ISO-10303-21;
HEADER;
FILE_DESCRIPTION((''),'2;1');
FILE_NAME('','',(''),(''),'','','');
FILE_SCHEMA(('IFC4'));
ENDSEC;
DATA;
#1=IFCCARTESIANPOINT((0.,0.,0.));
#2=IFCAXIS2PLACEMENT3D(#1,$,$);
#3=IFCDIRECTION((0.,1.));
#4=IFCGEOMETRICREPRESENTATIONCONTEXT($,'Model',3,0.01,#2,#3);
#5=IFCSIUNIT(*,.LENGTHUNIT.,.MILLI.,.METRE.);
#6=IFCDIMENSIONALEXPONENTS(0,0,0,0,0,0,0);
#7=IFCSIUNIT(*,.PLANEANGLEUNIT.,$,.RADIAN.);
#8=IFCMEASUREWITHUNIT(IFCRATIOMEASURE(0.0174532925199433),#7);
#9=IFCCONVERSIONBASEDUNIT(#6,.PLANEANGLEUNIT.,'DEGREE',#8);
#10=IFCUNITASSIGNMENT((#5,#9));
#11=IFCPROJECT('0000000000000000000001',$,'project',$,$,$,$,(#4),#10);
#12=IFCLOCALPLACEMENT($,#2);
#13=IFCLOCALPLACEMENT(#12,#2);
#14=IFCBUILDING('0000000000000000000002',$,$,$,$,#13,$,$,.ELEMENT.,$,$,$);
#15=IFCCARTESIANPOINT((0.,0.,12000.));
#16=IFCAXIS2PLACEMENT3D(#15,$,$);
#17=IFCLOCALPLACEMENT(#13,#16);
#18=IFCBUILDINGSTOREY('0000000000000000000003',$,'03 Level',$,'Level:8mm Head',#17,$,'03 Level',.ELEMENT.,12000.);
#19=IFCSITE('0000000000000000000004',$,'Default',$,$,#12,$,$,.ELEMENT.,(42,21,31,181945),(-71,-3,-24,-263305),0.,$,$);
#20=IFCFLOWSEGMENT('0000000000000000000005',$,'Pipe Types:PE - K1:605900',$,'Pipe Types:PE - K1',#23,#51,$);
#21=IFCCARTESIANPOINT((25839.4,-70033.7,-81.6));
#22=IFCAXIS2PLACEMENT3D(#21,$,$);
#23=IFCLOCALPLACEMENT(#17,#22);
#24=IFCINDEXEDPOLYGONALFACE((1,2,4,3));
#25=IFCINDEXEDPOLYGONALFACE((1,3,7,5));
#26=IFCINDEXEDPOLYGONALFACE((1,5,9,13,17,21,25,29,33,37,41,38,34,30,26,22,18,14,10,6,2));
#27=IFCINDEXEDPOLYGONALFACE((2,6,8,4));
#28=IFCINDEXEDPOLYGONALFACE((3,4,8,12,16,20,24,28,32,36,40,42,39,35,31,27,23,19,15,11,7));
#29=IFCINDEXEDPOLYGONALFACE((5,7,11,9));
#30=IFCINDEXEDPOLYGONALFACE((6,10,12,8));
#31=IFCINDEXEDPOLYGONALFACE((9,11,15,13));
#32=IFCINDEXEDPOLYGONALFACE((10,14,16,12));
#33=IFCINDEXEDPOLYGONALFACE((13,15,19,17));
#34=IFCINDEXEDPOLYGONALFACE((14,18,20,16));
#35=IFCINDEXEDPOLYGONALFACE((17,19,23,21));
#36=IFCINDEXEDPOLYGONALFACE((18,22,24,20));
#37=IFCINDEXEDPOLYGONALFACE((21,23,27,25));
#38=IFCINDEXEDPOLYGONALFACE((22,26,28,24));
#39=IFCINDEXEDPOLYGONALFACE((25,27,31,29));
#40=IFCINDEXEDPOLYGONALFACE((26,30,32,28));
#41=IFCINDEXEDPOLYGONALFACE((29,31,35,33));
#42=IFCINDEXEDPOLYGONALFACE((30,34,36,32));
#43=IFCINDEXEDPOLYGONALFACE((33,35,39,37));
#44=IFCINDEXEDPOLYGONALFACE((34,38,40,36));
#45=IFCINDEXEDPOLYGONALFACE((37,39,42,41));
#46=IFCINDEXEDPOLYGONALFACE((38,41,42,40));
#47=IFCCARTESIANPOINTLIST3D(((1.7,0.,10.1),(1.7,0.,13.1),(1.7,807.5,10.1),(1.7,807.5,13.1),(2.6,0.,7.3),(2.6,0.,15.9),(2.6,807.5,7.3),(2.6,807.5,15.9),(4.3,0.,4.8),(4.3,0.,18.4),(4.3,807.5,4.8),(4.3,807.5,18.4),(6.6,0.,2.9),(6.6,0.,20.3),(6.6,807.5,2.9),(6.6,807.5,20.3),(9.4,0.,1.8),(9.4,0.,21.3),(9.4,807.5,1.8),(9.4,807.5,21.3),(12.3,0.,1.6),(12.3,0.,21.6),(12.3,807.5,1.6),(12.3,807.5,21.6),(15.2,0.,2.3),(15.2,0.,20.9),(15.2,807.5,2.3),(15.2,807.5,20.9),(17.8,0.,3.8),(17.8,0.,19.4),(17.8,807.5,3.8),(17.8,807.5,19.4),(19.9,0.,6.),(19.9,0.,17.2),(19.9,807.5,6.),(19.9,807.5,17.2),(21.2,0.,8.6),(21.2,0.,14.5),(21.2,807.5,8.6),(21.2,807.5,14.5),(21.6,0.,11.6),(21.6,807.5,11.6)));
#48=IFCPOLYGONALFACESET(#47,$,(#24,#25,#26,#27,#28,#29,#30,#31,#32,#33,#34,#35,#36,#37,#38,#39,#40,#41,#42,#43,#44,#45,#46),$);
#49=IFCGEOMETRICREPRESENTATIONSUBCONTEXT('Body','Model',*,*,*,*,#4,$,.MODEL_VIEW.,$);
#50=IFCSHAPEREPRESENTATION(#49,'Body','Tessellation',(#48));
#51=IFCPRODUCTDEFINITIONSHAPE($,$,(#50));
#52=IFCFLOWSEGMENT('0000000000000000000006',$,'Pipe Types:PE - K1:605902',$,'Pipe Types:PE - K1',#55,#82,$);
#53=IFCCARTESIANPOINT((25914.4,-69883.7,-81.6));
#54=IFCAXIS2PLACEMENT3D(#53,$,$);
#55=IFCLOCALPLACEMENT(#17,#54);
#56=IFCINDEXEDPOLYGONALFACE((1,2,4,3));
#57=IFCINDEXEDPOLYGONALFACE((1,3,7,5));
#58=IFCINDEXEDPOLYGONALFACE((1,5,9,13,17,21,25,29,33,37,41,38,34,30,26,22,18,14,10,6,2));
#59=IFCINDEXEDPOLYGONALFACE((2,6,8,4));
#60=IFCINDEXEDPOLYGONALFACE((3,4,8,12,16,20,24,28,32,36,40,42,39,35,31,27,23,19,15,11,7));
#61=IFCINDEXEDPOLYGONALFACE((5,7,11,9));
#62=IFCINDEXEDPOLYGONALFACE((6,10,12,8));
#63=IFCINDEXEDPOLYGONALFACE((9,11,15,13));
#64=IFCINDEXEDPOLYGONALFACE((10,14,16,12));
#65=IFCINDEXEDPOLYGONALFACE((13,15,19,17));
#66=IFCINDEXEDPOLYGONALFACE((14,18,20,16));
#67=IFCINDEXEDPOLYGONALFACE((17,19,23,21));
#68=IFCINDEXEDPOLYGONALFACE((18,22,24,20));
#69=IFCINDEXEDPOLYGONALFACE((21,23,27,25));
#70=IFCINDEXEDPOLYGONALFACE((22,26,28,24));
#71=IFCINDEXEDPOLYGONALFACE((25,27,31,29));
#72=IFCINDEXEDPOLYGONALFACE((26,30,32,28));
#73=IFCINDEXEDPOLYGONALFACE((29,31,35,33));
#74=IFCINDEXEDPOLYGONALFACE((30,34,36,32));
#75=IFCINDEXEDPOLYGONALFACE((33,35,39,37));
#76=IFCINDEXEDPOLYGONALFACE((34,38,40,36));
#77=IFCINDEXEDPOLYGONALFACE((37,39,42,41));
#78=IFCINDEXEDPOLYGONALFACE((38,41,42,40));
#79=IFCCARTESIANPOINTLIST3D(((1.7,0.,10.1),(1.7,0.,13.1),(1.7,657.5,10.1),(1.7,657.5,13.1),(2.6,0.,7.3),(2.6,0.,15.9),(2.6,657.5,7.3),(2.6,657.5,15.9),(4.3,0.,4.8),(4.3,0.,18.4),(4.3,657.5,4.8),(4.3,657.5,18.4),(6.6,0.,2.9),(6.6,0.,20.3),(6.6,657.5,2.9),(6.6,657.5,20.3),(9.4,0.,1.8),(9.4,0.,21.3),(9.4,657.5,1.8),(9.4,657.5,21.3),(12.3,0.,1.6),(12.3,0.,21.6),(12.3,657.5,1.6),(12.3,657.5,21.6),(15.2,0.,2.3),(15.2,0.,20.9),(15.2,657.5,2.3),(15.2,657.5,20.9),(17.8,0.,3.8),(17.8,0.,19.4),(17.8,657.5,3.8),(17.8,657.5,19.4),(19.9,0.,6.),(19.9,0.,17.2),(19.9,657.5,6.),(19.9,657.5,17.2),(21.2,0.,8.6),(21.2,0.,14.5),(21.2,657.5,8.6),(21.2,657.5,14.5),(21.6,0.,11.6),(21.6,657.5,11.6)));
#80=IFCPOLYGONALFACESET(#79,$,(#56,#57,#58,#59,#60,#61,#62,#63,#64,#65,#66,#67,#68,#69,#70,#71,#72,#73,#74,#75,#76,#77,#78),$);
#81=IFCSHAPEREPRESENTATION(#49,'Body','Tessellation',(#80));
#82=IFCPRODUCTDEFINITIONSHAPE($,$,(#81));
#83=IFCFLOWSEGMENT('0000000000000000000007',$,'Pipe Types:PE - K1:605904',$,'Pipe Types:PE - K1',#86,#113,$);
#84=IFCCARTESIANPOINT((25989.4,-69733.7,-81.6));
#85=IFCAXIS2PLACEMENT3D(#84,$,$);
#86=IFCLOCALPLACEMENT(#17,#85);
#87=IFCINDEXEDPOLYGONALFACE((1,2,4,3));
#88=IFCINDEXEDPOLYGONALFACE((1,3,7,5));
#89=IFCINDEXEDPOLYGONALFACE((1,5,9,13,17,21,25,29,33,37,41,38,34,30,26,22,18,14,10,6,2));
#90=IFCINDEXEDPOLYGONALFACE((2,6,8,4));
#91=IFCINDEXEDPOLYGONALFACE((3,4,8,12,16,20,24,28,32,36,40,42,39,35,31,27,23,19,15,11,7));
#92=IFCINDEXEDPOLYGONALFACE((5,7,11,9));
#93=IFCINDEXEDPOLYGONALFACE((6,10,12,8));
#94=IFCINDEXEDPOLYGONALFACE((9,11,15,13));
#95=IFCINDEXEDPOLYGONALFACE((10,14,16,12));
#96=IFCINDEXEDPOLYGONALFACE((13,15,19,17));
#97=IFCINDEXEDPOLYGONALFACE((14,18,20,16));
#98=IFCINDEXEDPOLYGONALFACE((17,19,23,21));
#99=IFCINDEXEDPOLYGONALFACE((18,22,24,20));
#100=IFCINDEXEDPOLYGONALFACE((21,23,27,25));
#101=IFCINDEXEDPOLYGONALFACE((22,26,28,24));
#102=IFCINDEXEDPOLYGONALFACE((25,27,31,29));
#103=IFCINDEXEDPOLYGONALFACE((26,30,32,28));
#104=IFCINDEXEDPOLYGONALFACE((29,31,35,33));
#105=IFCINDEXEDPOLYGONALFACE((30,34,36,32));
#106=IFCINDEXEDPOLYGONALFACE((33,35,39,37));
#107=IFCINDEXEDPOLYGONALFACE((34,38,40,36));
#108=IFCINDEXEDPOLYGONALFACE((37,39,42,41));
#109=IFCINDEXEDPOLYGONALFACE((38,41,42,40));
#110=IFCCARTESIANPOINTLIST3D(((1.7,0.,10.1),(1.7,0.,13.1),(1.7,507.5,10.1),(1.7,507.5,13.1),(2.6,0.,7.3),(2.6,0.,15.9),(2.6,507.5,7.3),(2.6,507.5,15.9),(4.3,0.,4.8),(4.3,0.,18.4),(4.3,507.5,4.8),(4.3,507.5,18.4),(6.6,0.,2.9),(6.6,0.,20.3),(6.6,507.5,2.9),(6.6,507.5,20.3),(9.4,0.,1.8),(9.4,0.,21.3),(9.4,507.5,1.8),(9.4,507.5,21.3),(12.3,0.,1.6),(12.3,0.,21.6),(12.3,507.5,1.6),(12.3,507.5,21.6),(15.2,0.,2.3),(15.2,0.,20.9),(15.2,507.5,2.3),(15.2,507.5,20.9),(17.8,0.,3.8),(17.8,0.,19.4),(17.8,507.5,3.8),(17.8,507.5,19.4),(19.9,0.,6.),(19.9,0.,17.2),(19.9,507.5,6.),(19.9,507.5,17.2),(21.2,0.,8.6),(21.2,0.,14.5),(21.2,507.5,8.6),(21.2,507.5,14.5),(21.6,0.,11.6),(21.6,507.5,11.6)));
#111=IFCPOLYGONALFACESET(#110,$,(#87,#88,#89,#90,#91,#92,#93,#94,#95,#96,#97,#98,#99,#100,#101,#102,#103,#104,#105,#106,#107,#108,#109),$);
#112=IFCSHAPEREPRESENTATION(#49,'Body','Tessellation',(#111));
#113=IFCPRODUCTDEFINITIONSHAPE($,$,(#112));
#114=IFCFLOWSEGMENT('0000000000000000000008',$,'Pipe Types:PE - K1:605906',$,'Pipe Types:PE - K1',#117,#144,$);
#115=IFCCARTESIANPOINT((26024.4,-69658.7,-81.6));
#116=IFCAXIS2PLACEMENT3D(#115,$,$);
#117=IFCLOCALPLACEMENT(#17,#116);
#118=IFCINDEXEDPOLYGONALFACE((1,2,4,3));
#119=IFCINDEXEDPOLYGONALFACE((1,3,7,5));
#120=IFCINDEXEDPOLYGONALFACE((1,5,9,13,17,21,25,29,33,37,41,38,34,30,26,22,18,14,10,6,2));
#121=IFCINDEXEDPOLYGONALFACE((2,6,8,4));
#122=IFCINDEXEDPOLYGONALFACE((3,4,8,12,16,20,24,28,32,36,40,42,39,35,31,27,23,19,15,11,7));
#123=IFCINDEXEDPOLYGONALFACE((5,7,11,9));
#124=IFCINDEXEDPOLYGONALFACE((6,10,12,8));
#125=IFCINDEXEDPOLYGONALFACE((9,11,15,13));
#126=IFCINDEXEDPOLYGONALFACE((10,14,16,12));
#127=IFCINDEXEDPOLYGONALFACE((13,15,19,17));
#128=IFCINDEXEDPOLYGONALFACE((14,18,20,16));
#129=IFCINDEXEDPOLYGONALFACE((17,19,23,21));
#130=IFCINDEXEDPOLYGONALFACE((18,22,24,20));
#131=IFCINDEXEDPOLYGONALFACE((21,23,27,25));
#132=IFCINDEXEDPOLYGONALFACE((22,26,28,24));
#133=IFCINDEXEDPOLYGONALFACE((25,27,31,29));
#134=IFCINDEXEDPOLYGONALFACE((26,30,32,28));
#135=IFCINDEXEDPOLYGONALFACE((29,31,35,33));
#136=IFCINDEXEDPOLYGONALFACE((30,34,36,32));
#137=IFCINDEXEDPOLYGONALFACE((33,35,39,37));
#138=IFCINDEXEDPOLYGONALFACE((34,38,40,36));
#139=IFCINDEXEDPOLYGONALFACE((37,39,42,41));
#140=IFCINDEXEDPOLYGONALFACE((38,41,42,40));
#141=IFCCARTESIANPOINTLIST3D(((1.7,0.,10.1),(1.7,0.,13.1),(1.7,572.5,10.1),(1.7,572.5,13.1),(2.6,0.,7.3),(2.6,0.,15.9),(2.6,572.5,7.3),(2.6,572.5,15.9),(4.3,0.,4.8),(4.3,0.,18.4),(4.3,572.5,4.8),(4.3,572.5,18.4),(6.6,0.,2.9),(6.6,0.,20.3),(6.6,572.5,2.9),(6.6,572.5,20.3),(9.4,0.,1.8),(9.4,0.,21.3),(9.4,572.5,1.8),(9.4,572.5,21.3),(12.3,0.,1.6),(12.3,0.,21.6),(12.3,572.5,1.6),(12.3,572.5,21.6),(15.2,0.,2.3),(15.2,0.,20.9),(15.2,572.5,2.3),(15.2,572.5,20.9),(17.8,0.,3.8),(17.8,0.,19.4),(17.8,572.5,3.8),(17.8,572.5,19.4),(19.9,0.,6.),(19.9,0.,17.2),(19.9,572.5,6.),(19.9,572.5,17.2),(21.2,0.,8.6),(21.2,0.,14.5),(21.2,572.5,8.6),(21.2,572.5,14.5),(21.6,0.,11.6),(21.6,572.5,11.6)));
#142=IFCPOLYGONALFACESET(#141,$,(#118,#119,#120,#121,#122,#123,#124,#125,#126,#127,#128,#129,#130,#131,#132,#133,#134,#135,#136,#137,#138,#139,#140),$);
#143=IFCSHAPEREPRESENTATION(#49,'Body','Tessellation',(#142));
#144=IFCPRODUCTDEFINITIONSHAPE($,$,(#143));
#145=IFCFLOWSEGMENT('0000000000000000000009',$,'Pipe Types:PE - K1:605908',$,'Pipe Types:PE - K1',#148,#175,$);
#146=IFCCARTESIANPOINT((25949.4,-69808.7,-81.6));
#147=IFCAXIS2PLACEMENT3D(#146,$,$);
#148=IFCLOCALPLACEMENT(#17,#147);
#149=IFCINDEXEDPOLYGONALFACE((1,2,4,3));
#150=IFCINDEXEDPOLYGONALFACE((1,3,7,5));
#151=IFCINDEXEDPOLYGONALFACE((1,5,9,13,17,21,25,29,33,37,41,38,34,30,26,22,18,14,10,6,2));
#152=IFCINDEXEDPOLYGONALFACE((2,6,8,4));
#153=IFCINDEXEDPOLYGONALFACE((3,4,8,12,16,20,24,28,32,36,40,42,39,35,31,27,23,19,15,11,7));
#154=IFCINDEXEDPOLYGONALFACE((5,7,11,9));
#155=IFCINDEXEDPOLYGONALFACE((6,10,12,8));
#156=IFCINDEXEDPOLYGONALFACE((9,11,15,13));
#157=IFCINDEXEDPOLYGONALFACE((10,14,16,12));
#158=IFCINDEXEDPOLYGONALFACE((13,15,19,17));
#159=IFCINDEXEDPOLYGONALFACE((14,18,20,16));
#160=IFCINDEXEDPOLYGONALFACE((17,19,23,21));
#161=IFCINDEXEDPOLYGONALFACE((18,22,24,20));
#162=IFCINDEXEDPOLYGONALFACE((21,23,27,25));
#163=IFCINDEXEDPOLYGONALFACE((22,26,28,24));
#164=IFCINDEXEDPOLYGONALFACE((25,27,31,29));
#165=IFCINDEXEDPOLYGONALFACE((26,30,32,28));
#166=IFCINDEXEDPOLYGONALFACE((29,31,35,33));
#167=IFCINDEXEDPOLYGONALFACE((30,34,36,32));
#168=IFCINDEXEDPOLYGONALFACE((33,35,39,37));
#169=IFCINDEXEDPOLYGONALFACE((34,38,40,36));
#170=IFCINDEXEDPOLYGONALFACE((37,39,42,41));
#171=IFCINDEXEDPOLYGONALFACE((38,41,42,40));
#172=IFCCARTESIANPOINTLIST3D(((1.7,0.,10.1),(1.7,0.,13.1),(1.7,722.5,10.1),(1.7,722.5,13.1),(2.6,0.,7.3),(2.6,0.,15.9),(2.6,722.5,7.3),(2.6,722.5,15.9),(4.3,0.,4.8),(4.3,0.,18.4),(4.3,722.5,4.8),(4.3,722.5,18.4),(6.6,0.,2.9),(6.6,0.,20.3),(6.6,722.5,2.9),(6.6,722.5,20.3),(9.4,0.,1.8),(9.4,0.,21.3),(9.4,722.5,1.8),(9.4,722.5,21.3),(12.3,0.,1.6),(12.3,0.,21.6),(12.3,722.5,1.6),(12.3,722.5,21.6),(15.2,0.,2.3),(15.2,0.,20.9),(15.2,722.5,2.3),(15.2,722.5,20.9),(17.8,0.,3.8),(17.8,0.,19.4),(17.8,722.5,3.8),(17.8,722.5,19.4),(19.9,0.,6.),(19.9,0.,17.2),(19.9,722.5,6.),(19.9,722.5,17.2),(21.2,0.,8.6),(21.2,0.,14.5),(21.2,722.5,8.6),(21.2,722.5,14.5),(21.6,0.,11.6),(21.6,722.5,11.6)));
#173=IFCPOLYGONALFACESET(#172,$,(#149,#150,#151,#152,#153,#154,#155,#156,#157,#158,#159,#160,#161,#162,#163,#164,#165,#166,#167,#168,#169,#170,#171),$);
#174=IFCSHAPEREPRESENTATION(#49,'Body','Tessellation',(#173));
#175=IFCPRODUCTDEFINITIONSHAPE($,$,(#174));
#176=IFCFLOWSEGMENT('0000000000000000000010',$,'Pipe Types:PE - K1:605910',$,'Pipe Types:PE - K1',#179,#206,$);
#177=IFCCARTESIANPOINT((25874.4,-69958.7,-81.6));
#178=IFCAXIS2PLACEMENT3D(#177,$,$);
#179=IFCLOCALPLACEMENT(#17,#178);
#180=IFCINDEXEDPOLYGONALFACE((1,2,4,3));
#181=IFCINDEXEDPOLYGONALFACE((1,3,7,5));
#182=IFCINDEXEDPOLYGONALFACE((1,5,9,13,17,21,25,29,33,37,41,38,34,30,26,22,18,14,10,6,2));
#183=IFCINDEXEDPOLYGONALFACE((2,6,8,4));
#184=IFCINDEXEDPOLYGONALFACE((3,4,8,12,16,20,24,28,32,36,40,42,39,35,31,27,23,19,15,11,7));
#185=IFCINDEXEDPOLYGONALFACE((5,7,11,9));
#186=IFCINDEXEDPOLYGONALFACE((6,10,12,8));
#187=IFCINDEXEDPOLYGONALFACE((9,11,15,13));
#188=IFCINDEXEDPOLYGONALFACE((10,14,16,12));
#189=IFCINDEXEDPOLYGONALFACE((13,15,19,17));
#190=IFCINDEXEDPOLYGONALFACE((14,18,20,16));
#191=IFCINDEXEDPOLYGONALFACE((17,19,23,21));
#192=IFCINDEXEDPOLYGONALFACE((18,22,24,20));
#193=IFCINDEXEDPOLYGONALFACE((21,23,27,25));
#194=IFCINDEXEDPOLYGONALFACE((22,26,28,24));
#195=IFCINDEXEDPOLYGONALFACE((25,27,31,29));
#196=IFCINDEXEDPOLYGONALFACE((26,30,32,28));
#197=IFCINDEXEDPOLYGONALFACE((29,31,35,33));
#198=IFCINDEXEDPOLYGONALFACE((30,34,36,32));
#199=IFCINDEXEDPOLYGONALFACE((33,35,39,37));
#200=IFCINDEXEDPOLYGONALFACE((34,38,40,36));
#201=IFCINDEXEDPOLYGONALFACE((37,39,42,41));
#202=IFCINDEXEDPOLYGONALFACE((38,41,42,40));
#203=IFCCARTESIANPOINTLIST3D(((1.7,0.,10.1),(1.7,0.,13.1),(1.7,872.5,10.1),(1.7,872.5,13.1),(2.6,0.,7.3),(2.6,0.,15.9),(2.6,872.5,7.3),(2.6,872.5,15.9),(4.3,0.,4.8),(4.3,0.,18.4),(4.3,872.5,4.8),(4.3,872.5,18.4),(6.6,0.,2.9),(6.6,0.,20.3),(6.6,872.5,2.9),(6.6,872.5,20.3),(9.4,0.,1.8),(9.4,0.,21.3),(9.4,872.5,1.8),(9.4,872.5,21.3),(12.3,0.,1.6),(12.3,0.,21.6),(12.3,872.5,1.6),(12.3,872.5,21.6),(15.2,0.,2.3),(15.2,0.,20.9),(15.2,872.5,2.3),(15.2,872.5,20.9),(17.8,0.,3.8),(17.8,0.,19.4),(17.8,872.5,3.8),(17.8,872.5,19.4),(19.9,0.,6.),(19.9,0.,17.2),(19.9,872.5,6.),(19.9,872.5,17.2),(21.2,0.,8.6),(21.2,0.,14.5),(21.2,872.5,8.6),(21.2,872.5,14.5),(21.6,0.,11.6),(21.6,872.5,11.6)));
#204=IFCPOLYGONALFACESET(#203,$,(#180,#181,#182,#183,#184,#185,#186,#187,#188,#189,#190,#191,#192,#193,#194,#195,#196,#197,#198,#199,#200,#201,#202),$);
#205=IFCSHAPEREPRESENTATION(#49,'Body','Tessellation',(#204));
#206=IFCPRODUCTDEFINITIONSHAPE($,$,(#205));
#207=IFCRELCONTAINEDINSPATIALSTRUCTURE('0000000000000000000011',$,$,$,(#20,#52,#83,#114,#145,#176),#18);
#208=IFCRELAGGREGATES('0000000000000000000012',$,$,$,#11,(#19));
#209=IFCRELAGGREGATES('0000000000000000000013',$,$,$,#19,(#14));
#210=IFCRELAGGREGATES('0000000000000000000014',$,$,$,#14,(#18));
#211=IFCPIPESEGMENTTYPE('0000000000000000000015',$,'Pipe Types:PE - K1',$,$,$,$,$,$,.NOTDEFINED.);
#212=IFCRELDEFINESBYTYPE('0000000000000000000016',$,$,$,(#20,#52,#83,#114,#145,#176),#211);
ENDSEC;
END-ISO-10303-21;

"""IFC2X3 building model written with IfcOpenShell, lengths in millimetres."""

from ifc_helpers import new_model, entity, si_unit, converted_unit, direction, frame, frame_2d, origin, origin_2d_with_axis, place, context, subcontext, project, spatial, circle, extrude, type_object, element, save


model = new_model("IFC2X3")

# Units and contexts
model_context = context("Model", 3, precision=0.01, world=origin(), true_north=direction((0.0, 1.0)))
body_context = subcontext(model_context, "Body", "Model", "MODEL_VIEW")
ifc_project = project(units=[si_unit("LENGTHUNIT", "METRE", prefix="MILLI"), converted_unit("PLANEANGLEUNIT", "DEGREE", entity("IfcRatioMeasure", 0.0174532925199433), si_unit("PLANEANGLEUNIT", "RADIAN"), dimensions=[0, 0, 0, 0, 0, 0, 0])], contexts=[model_context])

# Site, building, storey
site_placement = place(None, origin())
site = spatial("IfcSite", under=ifc_project, at=site_placement, Name="Default", CompositionType="ELEMENT", RefLatitude=(42, 21, 31, 181945), RefLongitude=(-71, -3, -24, -263305), RefElevation=0.0)
building_placement = place(site_placement, origin())
building = spatial("IfcBuilding", under=site, at=building_placement, CompositionType="ELEMENT")
storey_placement = place(building_placement, frame((0.0, 0.0, 12000.0)))
storey = spatial("IfcBuildingStorey", under=building, at=storey_placement, Name="03 Level", ObjectType="Level:8mm Head", LongName="03 Level", CompositionType="ELEMENT", Elevation=12000.0)

# Flow segments
pipe_segment_type = type_object("IfcPipeSegmentType", Name="Pipe Types:PE - K1", PredefinedType="NOTDEFINED")
flow_segment_1_placement = place(storey_placement, frame((25839.4, -70033.7, -81.6)))
element("IfcFlowSegment", 1, at=flow_segment_1_placement, inside=storey, type_object=pipe_segment_type, Name="Pipe Types:PE - K1:605900", ObjectType="Pipe Types:PE - K1", context=body_context, shape_type="SweptSolid", body=[
    extrude(circle(Radius=10.0, at=frame_2d((0.0, 0.0), x_axis=(1.0, 0.0))), frame((11.6, 0.0, 11.6), z_axis=(0.0, 1.0, 0.0), x_axis=(1.0, 0.0, 0.0)), (0.0, 0.0, 1.0), 807.5),
])
flow_segment_2_placement = place(storey_placement, frame((25914.4, -69883.7, -81.6)))
element("IfcFlowSegment", 2, at=flow_segment_2_placement, inside=storey, type_object=pipe_segment_type, Name="Pipe Types:PE - K1:605902", ObjectType="Pipe Types:PE - K1", context=body_context, shape_type="SweptSolid", body=[
    extrude(circle(Radius=10.0, at=origin_2d_with_axis()), frame((11.6, 0.0, 11.6), z_axis=(0.0, 1.0, 0.0), x_axis=(1.0, 0.0, 0.0)), (0.0, 0.0, 1.0), 657.5),
])
flow_segment_3_placement = place(storey_placement, frame((25989.4, -69733.7, -81.6)))
element("IfcFlowSegment", 3, at=flow_segment_3_placement, inside=storey, type_object=pipe_segment_type, Name="Pipe Types:PE - K1:605904", ObjectType="Pipe Types:PE - K1", context=body_context, shape_type="SweptSolid", body=[
    extrude(circle(Radius=10.0, at=origin_2d_with_axis()), frame((11.6, 0.0, 11.6), z_axis=(0.0, 1.0, 0.0), x_axis=(1.0, 0.0, 0.0)), (0.0, 0.0, 1.0), 507.5),
])
flow_segment_4_placement = place(storey_placement, frame((26024.4, -69658.7, -81.6)))
element("IfcFlowSegment", 4, at=flow_segment_4_placement, inside=storey, type_object=pipe_segment_type, Name="Pipe Types:PE - K1:605906", ObjectType="Pipe Types:PE - K1", context=body_context, shape_type="SweptSolid", body=[
    extrude(circle(Radius=10.0, at=origin_2d_with_axis()), frame((11.6, 0.0, 11.6), z_axis=(0.0, 1.0, 0.0), x_axis=(1.0, 0.0, 0.0)), (0.0, 0.0, 1.0), 572.5),
])
flow_segment_5_placement = place(storey_placement, frame((25949.4, -69808.7, -81.6)))
element("IfcFlowSegment", 5, at=flow_segment_5_placement, inside=storey, type_object=pipe_segment_type, Name="Pipe Types:PE - K1:605908", ObjectType="Pipe Types:PE - K1", context=body_context, shape_type="SweptSolid", body=[
    extrude(circle(Radius=10.0, at=frame_2d((0.0, 0.0), x_axis=(1.0, 0.0))), frame((11.6, 0.0, 11.6), z_axis=(0.0, 1.0, 0.0), x_axis=(1.0, 0.0, 0.0)), (0.0, 0.0, 1.0), 722.5),
])
flow_segment_6_placement = place(storey_placement, frame((25874.4, -69958.7, -81.6)))
element("IfcFlowSegment", 6, at=flow_segment_6_placement, inside=storey, type_object=pipe_segment_type, Name="Pipe Types:PE - K1:605910", ObjectType="Pipe Types:PE - K1", context=body_context, shape_type="SweptSolid", body=[
    extrude(circle(Radius=10.0, at=origin_2d_with_axis()), frame((11.6, 0.0, 11.6), z_axis=(0.0, 1.0, 0.0), x_axis=(1.0, 0.0, 0.0)), (0.0, 0.0, 1.0), 872.5),
])

save(model, "model.ifc")
